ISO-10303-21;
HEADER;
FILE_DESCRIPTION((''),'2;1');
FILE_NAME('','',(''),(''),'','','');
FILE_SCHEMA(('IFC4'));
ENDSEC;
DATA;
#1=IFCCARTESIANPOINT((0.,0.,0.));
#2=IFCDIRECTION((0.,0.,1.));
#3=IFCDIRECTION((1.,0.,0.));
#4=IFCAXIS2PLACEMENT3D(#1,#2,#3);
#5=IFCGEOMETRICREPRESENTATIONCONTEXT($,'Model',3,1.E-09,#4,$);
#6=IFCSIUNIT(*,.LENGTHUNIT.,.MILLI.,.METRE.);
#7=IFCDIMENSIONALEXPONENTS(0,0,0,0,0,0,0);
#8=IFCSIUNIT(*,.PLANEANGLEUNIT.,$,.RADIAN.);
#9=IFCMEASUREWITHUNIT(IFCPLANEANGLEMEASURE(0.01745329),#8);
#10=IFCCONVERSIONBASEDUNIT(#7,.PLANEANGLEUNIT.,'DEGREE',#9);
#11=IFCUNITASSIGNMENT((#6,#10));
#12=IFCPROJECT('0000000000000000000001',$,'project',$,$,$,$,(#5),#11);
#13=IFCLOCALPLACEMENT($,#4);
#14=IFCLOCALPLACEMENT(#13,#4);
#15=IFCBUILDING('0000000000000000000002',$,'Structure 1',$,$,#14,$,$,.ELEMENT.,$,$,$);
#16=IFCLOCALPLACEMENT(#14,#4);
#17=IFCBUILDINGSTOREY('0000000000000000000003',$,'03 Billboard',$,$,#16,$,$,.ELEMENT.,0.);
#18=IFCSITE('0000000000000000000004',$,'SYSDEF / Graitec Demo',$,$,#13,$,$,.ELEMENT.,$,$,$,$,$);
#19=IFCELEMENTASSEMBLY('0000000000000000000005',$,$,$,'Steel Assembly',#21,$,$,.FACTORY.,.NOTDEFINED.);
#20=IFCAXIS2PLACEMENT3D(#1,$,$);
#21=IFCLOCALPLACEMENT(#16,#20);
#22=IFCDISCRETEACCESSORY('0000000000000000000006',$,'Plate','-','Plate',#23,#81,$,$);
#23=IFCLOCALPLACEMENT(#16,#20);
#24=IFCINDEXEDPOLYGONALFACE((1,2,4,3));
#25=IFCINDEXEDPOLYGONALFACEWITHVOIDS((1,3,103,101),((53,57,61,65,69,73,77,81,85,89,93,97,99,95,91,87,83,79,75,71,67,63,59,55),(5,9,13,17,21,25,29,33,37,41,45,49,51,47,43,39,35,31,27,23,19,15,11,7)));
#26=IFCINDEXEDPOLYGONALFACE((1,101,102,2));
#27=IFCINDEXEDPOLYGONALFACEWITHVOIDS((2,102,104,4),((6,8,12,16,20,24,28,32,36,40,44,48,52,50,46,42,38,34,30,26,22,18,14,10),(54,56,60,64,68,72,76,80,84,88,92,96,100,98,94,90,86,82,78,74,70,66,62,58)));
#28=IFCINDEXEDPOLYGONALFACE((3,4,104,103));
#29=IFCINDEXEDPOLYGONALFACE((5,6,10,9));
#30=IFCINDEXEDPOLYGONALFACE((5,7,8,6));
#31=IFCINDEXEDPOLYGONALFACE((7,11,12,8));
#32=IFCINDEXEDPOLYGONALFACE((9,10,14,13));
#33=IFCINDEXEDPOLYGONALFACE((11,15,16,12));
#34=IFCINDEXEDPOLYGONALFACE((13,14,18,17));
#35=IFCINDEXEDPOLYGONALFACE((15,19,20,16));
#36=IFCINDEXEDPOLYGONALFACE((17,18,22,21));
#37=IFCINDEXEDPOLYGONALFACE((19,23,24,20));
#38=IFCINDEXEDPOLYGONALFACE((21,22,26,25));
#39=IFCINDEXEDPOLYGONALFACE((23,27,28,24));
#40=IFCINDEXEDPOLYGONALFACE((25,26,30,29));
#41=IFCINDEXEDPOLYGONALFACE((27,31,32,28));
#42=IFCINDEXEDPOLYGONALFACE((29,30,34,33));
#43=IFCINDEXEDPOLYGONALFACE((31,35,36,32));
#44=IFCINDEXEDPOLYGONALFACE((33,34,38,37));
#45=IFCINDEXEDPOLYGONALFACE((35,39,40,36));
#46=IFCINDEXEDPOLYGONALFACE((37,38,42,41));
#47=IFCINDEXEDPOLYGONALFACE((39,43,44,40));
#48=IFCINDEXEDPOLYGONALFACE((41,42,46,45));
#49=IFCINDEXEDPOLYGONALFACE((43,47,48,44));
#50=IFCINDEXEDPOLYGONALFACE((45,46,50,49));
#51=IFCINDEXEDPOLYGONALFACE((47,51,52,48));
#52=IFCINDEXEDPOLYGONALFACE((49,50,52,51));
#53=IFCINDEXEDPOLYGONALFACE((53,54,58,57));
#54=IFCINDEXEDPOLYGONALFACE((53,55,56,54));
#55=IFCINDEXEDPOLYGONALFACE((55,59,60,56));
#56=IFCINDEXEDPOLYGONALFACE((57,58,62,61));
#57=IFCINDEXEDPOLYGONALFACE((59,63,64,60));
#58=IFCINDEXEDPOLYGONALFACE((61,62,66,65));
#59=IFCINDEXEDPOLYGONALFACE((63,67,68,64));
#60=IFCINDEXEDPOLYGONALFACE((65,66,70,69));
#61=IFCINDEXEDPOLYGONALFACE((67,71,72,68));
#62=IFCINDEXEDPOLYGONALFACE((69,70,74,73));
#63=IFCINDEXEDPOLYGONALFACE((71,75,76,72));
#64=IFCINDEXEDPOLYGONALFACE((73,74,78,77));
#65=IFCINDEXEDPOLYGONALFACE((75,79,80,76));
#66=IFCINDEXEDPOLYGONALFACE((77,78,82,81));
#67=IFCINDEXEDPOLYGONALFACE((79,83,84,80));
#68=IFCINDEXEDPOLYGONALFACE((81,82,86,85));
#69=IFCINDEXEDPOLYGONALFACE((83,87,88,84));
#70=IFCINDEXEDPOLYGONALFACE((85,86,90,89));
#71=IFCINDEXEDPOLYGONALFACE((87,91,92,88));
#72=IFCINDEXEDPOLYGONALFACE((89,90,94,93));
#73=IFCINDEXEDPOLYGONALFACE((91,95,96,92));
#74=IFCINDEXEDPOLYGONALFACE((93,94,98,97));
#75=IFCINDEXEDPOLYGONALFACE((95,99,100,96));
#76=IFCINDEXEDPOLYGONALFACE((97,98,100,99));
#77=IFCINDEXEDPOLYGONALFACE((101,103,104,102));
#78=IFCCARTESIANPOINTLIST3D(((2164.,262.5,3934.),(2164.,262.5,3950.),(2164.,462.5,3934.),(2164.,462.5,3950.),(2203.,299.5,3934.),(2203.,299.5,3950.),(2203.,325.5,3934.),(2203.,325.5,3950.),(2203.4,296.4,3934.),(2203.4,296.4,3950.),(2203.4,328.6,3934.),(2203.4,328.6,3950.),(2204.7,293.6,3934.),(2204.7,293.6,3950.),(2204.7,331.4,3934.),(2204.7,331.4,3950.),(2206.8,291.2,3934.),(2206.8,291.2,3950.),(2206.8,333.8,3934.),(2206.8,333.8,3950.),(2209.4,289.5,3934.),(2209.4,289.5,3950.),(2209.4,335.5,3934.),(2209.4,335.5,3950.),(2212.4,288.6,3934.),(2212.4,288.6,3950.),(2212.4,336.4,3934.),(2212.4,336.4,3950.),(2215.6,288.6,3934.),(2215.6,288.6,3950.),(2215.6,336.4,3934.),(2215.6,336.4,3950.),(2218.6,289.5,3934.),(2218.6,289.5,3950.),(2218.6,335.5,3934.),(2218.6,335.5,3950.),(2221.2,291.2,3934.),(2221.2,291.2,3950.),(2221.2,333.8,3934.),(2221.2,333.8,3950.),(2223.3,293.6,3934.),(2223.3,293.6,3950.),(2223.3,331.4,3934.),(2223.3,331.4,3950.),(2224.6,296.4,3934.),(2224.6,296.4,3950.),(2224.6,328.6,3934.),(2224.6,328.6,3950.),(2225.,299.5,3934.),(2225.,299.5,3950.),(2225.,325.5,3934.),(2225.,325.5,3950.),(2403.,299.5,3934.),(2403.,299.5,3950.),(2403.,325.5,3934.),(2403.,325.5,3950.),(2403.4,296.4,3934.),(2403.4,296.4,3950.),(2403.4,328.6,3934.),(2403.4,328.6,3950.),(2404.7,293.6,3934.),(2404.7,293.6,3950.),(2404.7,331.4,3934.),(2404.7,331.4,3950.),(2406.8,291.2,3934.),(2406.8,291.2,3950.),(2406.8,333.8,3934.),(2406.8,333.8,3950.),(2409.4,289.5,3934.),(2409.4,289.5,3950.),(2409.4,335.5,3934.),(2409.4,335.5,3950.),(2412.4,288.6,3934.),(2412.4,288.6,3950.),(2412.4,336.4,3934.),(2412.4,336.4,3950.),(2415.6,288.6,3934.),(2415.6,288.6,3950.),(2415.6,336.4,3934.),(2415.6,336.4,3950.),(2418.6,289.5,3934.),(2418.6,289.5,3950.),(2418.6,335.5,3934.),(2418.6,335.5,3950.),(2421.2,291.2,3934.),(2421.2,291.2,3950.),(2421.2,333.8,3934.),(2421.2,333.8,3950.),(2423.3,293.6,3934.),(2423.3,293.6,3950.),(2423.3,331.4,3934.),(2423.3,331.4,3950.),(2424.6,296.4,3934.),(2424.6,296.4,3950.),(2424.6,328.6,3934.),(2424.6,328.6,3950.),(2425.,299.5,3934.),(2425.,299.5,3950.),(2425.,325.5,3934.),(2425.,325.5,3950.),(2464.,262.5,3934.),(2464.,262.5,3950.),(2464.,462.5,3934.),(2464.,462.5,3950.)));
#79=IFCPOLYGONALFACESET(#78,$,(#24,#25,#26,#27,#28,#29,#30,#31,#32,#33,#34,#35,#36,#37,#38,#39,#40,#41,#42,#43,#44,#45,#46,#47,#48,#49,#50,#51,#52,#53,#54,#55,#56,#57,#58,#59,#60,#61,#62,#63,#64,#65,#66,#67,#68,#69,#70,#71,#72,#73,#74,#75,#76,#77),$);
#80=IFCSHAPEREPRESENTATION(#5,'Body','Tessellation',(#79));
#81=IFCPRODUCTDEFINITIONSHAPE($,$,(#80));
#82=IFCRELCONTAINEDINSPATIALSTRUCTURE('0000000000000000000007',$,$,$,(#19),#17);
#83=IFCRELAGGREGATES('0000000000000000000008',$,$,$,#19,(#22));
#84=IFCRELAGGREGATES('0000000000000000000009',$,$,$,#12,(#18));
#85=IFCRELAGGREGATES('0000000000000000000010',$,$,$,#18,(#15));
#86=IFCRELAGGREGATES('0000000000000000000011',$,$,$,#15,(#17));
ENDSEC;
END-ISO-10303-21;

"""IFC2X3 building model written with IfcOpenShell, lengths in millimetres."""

from ifc_helpers import new_model, entity, si_unit, converted_unit, point, frame, frame_2d, origin, origin_with_axes, place, context, project, spatial, polyline, circle_curve, line_curve, trimmed, segment, composite_curve, outline, extrude, element, aggregate, save


model = new_model("IFC2X3")

# Units and contexts
model_context = context("Model", 3, precision=1e-09, world=origin_with_axes())
ifc_project = project(units=[si_unit("LENGTHUNIT", "METRE", prefix="MILLI"), converted_unit("PLANEANGLEUNIT", "DEGREE", entity("IfcPlaneAngleMeasure", 0.01745329), si_unit("PLANEANGLEUNIT", "RADIAN"), dimensions=[0, 0, 0, 0, 0, 0, 0])], contexts=[model_context])

# Site, building, storey
site_placement = place(None, origin_with_axes())
site = spatial("IfcSite", under=ifc_project, at=site_placement, Name="SYSDEF / Graitec Demo", CompositionType="ELEMENT")
building_placement = place(site_placement, origin_with_axes())
building = spatial("IfcBuilding", under=site, at=building_placement, Name="Structure 1", CompositionType="ELEMENT")
storey_placement = place(building_placement, origin_with_axes())
storey = spatial("IfcBuildingStorey", under=building, at=storey_placement, Name="03 Billboard", CompositionType="ELEMENT", Elevation=0.0)

# Element assembly
assembly_1_placement = place(None, frame((-4406.3, 0.0, 3558.0), z_axis=(-1.0, 0.0, 0.0), x_axis=(0.0, -1.0, 0.0)))
assembly_1 = element("IfcElementAssembly", 1, at=assembly_1_placement, inside=storey, ObjectType="Steel Assembly", AssemblyPlace="FACTORY", PredefinedType="NOTDEFINED")

# Discrete accessory, openings
discrete_accessory_1_placement = place(assembly_1_placement, frame((-462.5, 392.0, -6870.3), z_axis=(0.0, -1.0, 0.0), x_axis=(1.0, 0.0, 0.0)))
discrete_accessory_1 = element("IfcDiscreteAccessory", 2, at=discrete_accessory_1_placement, Name="Plate", Description="-", ObjectType="Plate", context=model_context, shape_type="SweptSolid", body=[
    extrude(outline(polyline([(0.0, 0.0), (200.0, 0.0), (200.0, 300.0), (0.0, 300.0), (0.0, 0.0)])), origin_with_axes(), (0.0, 0.0, 1.0), 16.0),
])
opening_1_placement = place(discrete_accessory_1_placement, frame((150.0, 150.0, -0.5), z_axis=(0.0, 0.0, 1.0), x_axis=(0.0, 1.0, 0.0)))
element("IfcOpeningElement", 3, at=opening_1_placement, cuts=discrete_accessory_1, ObjectType="Opening", context=model_context, shape_type="SweptSolid", body=[
    extrude(outline(composite_curve([segment(trimmed(line_curve((111.0, -13.0), (0.0, 1.0), 26.0), [point((111.0, -13.0))], [point((111.0, 13.0))], True, "CARTESIAN"), True, "CONTINUOUS"), segment(trimmed(circle_curve(frame_2d((100.0, 13.0), x_axis=(1.0, 0.0)), 11.0), [point((111.0, 13.0))], [point((89.0, 13.0))], True, "CARTESIAN"), True, "CONTINUOUS"), segment(trimmed(line_curve((89.0, 13.0), (0.0, -1.0), 26.0), [point((89.0, 13.0))], [point((89.0, -13.0))], True, "CARTESIAN"), True, "CONTINUOUS"), segment(trimmed(circle_curve(frame_2d((100.0, -13.0), x_axis=(1.0, 0.0)), 11.0), [point((89.0, -13.0))], [point((111.0, -13.0))], True, "CARTESIAN"), True, "CONTINUOUS")], self_intersect=False)), origin(), (0.0, 0.0, 1.0), 17.0),
])
opening_2_placement = place(discrete_accessory_1_placement, frame((150.0, 150.0, -0.5), z_axis=(0.0, 0.0, 1.0), x_axis=(0.0, 1.0, 0.0)))
element("IfcOpeningElement", 4, at=opening_2_placement, cuts=discrete_accessory_1, ObjectType="Opening", context=model_context, shape_type="SweptSolid", body=[
    extrude(outline(composite_curve([segment(trimmed(line_curve((-89.0, -13.0), (0.0, 1.0), 26.0), [point((-89.0, -13.0))], [point((-89.0, 13.0))], True, "CARTESIAN"), True, "CONTINUOUS"), segment(trimmed(circle_curve(frame_2d((-100.0, 13.0), x_axis=(1.0, 0.0)), 11.0), [point((-89.0, 13.0))], [point((-111.0, 13.0))], True, "CARTESIAN"), True, "CONTINUOUS"), segment(trimmed(line_curve((-111.0, 13.0), (0.0, -1.0), 26.0), [point((-111.0, 13.0))], [point((-111.0, -13.0))], True, "CARTESIAN"), True, "CONTINUOUS"), segment(trimmed(circle_curve(frame_2d((-100.0, -13.0), x_axis=(1.0, 0.0)), 11.0), [point((-111.0, -13.0))], [point((-89.0, -13.0))], True, "CARTESIAN"), True, "CONTINUOUS")], self_intersect=False)), origin(), (0.0, 0.0, 1.0), 17.0),
])
aggregate(assembly_1, [discrete_accessory_1])

save(model, "model.ifc")
